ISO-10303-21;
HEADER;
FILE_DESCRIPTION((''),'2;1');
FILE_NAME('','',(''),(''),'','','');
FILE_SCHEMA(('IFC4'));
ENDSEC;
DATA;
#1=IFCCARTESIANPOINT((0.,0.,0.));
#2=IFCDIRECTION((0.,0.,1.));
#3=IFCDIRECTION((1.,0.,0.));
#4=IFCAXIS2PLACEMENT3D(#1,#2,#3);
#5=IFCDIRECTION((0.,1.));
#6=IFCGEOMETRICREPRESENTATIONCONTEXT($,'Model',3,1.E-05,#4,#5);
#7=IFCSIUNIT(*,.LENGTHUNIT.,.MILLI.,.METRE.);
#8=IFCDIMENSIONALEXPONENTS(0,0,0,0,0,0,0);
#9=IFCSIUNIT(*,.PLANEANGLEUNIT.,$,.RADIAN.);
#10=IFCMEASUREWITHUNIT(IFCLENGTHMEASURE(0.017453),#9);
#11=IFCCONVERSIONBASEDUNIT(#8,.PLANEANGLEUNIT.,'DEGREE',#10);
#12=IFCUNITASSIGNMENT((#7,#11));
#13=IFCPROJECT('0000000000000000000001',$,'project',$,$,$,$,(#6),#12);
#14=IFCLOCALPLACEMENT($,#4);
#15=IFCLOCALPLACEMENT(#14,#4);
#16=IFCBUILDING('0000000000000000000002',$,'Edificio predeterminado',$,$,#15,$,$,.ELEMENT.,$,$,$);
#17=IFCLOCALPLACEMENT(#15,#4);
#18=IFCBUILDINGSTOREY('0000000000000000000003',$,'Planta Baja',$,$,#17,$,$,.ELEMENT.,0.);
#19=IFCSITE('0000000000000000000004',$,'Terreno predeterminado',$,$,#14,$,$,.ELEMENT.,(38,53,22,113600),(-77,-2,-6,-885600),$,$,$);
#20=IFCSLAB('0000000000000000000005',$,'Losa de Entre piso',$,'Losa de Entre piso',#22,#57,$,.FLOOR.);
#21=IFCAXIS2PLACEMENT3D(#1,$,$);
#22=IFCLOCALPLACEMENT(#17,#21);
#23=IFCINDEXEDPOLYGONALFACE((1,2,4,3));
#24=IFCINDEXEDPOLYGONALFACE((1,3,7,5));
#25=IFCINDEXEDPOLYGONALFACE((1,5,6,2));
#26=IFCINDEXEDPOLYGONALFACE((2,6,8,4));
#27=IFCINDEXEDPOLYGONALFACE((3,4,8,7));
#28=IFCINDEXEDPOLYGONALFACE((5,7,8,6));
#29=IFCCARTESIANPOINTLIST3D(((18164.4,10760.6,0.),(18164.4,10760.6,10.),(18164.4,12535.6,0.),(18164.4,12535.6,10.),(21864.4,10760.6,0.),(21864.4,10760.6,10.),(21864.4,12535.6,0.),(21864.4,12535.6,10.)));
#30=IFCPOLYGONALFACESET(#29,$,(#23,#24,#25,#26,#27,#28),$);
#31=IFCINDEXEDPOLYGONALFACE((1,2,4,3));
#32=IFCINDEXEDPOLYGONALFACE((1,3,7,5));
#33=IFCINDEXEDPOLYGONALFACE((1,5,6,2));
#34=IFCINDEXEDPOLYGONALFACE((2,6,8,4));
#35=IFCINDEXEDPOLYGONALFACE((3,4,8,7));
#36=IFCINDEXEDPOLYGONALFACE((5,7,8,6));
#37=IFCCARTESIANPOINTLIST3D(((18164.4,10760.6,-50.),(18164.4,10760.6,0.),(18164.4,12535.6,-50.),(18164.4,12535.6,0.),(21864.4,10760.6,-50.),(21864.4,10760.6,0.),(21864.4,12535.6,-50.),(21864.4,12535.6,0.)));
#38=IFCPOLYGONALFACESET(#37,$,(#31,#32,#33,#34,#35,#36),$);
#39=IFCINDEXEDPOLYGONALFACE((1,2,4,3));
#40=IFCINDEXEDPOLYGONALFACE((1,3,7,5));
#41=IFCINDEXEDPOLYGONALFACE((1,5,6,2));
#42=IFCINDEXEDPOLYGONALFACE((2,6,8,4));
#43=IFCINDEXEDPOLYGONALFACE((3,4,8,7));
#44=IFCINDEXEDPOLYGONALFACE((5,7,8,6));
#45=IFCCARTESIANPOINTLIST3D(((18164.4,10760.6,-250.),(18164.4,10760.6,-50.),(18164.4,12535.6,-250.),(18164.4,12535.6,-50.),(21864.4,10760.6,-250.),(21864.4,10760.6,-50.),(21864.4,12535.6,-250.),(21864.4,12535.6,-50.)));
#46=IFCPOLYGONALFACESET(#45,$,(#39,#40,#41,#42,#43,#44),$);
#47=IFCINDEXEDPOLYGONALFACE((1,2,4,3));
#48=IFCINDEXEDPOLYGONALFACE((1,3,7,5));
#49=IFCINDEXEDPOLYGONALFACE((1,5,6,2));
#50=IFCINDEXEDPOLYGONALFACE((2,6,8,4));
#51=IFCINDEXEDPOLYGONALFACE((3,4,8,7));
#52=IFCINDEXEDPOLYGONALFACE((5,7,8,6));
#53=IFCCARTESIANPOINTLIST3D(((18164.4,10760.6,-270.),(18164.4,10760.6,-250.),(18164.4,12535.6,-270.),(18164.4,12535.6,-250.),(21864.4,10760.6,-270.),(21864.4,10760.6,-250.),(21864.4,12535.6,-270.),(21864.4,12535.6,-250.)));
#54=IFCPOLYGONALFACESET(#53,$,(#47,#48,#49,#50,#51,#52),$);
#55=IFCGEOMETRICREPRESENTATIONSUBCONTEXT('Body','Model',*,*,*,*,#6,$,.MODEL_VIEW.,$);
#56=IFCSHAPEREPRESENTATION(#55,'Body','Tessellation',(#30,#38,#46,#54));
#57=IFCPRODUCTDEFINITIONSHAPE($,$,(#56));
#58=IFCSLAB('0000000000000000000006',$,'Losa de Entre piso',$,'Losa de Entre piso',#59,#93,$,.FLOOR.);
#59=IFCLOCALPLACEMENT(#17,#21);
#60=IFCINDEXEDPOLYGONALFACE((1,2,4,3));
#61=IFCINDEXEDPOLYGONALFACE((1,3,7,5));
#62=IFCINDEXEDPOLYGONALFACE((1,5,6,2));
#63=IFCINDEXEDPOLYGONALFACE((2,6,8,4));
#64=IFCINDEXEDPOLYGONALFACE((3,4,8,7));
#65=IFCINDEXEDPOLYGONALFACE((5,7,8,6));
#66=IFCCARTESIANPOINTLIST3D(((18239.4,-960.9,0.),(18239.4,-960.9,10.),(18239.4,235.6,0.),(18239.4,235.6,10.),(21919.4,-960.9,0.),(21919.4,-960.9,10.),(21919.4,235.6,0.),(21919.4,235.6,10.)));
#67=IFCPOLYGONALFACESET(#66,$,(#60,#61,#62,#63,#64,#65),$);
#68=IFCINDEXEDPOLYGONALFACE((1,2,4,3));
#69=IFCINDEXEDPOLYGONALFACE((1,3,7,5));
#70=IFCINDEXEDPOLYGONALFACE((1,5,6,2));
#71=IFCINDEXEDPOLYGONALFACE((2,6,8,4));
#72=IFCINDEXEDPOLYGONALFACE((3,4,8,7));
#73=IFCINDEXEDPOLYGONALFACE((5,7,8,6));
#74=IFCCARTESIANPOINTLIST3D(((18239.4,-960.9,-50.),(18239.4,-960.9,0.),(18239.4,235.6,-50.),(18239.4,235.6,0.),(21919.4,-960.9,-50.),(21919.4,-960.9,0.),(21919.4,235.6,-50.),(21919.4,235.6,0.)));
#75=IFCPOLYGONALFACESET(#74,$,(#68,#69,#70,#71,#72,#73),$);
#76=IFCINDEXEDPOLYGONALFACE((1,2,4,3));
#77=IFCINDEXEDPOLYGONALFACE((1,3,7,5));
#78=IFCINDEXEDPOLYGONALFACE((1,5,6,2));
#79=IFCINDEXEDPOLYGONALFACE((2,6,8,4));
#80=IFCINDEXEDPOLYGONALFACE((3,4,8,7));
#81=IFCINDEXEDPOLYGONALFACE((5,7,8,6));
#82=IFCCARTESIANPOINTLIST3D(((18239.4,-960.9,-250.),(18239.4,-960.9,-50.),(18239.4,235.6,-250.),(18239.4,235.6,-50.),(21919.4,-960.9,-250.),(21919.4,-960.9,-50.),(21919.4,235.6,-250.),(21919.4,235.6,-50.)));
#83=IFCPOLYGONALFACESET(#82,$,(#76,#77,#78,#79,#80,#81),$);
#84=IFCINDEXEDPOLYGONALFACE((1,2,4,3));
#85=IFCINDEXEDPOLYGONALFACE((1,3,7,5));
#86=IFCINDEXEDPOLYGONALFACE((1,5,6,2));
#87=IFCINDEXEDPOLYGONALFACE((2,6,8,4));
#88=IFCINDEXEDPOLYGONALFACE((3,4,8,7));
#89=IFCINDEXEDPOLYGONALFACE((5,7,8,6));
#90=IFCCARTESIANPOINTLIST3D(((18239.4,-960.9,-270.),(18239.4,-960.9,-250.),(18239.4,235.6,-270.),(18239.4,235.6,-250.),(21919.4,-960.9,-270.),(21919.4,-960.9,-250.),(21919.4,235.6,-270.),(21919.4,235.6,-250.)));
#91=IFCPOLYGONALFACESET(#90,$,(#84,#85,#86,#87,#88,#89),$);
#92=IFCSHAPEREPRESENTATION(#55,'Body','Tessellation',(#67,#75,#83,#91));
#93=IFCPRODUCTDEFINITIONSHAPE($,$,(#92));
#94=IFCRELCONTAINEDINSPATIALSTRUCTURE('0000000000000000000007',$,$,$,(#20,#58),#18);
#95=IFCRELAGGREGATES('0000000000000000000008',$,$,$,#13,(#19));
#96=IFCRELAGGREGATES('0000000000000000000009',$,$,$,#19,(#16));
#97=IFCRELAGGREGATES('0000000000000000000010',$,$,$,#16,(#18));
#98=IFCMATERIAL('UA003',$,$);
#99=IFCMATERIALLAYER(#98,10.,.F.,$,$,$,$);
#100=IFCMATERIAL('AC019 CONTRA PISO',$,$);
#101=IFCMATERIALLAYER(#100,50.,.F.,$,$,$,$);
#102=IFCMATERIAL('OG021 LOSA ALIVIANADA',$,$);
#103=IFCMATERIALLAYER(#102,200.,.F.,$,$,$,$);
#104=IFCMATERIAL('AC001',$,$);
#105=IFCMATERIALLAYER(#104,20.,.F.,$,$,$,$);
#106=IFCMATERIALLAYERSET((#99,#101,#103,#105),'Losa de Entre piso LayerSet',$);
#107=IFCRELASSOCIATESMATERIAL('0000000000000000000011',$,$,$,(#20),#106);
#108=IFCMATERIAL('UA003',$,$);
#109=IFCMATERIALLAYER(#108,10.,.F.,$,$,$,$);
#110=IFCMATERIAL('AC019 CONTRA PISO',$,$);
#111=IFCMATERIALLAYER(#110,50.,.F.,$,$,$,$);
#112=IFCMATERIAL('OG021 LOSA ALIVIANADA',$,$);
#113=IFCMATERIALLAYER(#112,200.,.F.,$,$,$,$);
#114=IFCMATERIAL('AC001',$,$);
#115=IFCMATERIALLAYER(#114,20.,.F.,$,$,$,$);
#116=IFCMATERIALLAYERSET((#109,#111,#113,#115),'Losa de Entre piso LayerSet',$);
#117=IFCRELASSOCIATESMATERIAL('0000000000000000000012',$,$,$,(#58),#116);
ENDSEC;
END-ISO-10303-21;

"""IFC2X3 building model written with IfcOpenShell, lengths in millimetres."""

from ifc_helpers import new_model, entity, si_unit, converted_unit, direction, frame, origin_with_axes, place, context, subcontext, project, spatial, polyline, outline, extrude, material, layer, layer_set, layer_usage, element, save


model = new_model("IFC2X3")

# Units and contexts
model_context = context("Model", 3, precision=1e-05, world=origin_with_axes(), true_north=direction((0.0, 1.0)))
body_context = subcontext(model_context, "Body", "Model", "MODEL_VIEW")
ifc_project = project(units=[si_unit("LENGTHUNIT", "METRE", prefix="MILLI"), converted_unit("PLANEANGLEUNIT", "DEGREE", entity("IfcLengthMeasure", 0.017453), si_unit("PLANEANGLEUNIT", "RADIAN"), dimensions=[0, 0, 0, 0, 0, 0, 0])], contexts=[model_context])

# Site, building, storey
site_placement = place(None, origin_with_axes())
site = spatial("IfcSite", under=ifc_project, at=site_placement, Name="Terreno predeterminado", CompositionType="ELEMENT", RefLatitude=(38, 53, 22, 113600), RefLongitude=(-77, -2, -6, -885600))
building_placement = place(site_placement, origin_with_axes())
building = spatial("IfcBuilding", under=site, at=building_placement, Name="Edificio predeterminado", CompositionType="ELEMENT")
storey_placement = place(building_placement, origin_with_axes())
storey = spatial("IfcBuildingStorey", under=building, at=storey_placement, Name="Planta Baja", CompositionType="ELEMENT", Elevation=0.0)

# Slabs
ifc_material_1 = material(Name="UA003")
ifc_layer_1 = layer(ifc_material_1, 10.0, ventilated=False)
ifc_material_2 = material(Name="AC019 CONTRA PISO")
ifc_layer_2 = layer(ifc_material_2, 50.0, ventilated=False)
ifc_material_3 = material(Name="OG021 LOSA ALIVIANADA")
ifc_layer_3 = layer(ifc_material_3, 200.0, ventilated=False)
ifc_material_4 = material(Name="AC001")
ifc_layer_4 = layer(ifc_material_4, 20.0, ventilated=False)
ifc_layer_set_1 = layer_set([ifc_layer_1, ifc_layer_2, ifc_layer_3, ifc_layer_4], Name="Losa de Entre piso LayerSet")
ifc_layer_usage_1 = layer_usage(ifc_layer_set_1, "AXIS3", "POSITIVE", 0.0)
slab_1_placement = place(storey_placement, origin_with_axes())
element("IfcSlab", 1, at=slab_1_placement, inside=storey, material=ifc_layer_usage_1, Name="Losa de Entre piso", ObjectType="Losa de Entre piso", PredefinedType="FLOOR", context=body_context, shape_type="SweptSolid", body=[
    extrude(outline(polyline([(0.0, 0.0), (1775.0, 0.0), (1775.0, 3700.0), (0.0, 3700.0), (0.0, 0.0)])), frame((21864.4, 12535.6, 0.0), z_axis=(0.0, 0.0, -1.0), x_axis=(0.0, -1.0, 0.0)), (0.0, 0.0, -1.0), 10.0),
    extrude(outline(polyline([(0.0, 0.0), (1775.0, 0.0), (1775.0, 3700.0), (0.0, 3700.0), (0.0, 0.0)])), frame((21864.4, 12535.6, -50.0), z_axis=(0.0, 0.0, -1.0), x_axis=(0.0, -1.0, 0.0)), (0.0, 0.0, -1.0), 50.0),
    extrude(outline(polyline([(0.0, 0.0), (1775.0, 0.0), (1775.0, 3700.0), (0.0, 3700.0), (0.0, 0.0)])), frame((21864.4, 12535.6, -250.0), z_axis=(0.0, 0.0, -1.0), x_axis=(0.0, -1.0, 0.0)), (0.0, 0.0, -1.0), 200.0),
    extrude(outline(polyline([(0.0, 0.0), (1775.0, 0.0), (1775.0, 3700.0), (0.0, 3700.0), (0.0, 0.0)])), frame((21864.4, 12535.6, -270.0), z_axis=(0.0, 0.0, -1.0), x_axis=(0.0, -1.0, 0.0)), (0.0, 0.0, -1.0), 20.0),
])
ifc_material_5 = material(Name="UA003")
ifc_layer_5 = layer(ifc_material_5, 10.0, ventilated=False)
ifc_material_6 = material(Name="AC019 CONTRA PISO")
ifc_layer_6 = layer(ifc_material_6, 50.0, ventilated=False)
ifc_material_7 = material(Name="OG021 LOSA ALIVIANADA")
ifc_layer_7 = layer(ifc_material_7, 200.0, ventilated=False)
ifc_material_8 = material(Name="AC001")
ifc_layer_8 = layer(ifc_material_8, 20.0, ventilated=False)
ifc_layer_set_2 = layer_set([ifc_layer_5, ifc_layer_6, ifc_layer_7, ifc_layer_8], Name="Losa de Entre piso LayerSet")
ifc_layer_usage_2 = layer_usage(ifc_layer_set_2, "AXIS3", "POSITIVE", 0.0)
slab_2_placement = place(storey_placement, origin_with_axes())
element("IfcSlab", 2, at=slab_2_placement, inside=storey, material=ifc_layer_usage_2, Name="Losa de Entre piso", ObjectType="Losa de Entre piso", PredefinedType="FLOOR", context=body_context, shape_type="SweptSolid", body=[
    extrude(outline(polyline([(0.0, 0.0), (1196.6, 0.0), (1196.6, 3680.0), (0.0, 3680.0), (0.0, 0.0)])), frame((21919.4, 235.6, 0.0), z_axis=(0.0, 0.0, -1.0), x_axis=(0.0, -1.0, 0.0)), (0.0, 0.0, -1.0), 10.0),
    extrude(outline(polyline([(0.0, 0.0), (1196.6, 0.0), (1196.6, 3680.0), (0.0, 3680.0), (0.0, 0.0)])), frame((21919.4, 235.6, -50.0), z_axis=(0.0, 0.0, -1.0), x_axis=(0.0, -1.0, 0.0)), (0.0, 0.0, -1.0), 50.0),
    extrude(outline(polyline([(0.0, 0.0), (1196.6, 0.0), (1196.6, 3680.0), (0.0, 3680.0), (0.0, 0.0)])), frame((21919.4, 235.6, -250.0), z_axis=(0.0, 0.0, -1.0), x_axis=(0.0, -1.0, 0.0)), (0.0, 0.0, -1.0), 200.0),
    extrude(outline(polyline([(0.0, 0.0), (1196.6, 0.0), (1196.6, 3680.0), (0.0, 3680.0), (0.0, 0.0)])), frame((21919.4, 235.6, -270.0), z_axis=(0.0, 0.0, -1.0), x_axis=(0.0, -1.0, 0.0)), (0.0, 0.0, -1.0), 20.0),
])

save(model, "model.ifc")
